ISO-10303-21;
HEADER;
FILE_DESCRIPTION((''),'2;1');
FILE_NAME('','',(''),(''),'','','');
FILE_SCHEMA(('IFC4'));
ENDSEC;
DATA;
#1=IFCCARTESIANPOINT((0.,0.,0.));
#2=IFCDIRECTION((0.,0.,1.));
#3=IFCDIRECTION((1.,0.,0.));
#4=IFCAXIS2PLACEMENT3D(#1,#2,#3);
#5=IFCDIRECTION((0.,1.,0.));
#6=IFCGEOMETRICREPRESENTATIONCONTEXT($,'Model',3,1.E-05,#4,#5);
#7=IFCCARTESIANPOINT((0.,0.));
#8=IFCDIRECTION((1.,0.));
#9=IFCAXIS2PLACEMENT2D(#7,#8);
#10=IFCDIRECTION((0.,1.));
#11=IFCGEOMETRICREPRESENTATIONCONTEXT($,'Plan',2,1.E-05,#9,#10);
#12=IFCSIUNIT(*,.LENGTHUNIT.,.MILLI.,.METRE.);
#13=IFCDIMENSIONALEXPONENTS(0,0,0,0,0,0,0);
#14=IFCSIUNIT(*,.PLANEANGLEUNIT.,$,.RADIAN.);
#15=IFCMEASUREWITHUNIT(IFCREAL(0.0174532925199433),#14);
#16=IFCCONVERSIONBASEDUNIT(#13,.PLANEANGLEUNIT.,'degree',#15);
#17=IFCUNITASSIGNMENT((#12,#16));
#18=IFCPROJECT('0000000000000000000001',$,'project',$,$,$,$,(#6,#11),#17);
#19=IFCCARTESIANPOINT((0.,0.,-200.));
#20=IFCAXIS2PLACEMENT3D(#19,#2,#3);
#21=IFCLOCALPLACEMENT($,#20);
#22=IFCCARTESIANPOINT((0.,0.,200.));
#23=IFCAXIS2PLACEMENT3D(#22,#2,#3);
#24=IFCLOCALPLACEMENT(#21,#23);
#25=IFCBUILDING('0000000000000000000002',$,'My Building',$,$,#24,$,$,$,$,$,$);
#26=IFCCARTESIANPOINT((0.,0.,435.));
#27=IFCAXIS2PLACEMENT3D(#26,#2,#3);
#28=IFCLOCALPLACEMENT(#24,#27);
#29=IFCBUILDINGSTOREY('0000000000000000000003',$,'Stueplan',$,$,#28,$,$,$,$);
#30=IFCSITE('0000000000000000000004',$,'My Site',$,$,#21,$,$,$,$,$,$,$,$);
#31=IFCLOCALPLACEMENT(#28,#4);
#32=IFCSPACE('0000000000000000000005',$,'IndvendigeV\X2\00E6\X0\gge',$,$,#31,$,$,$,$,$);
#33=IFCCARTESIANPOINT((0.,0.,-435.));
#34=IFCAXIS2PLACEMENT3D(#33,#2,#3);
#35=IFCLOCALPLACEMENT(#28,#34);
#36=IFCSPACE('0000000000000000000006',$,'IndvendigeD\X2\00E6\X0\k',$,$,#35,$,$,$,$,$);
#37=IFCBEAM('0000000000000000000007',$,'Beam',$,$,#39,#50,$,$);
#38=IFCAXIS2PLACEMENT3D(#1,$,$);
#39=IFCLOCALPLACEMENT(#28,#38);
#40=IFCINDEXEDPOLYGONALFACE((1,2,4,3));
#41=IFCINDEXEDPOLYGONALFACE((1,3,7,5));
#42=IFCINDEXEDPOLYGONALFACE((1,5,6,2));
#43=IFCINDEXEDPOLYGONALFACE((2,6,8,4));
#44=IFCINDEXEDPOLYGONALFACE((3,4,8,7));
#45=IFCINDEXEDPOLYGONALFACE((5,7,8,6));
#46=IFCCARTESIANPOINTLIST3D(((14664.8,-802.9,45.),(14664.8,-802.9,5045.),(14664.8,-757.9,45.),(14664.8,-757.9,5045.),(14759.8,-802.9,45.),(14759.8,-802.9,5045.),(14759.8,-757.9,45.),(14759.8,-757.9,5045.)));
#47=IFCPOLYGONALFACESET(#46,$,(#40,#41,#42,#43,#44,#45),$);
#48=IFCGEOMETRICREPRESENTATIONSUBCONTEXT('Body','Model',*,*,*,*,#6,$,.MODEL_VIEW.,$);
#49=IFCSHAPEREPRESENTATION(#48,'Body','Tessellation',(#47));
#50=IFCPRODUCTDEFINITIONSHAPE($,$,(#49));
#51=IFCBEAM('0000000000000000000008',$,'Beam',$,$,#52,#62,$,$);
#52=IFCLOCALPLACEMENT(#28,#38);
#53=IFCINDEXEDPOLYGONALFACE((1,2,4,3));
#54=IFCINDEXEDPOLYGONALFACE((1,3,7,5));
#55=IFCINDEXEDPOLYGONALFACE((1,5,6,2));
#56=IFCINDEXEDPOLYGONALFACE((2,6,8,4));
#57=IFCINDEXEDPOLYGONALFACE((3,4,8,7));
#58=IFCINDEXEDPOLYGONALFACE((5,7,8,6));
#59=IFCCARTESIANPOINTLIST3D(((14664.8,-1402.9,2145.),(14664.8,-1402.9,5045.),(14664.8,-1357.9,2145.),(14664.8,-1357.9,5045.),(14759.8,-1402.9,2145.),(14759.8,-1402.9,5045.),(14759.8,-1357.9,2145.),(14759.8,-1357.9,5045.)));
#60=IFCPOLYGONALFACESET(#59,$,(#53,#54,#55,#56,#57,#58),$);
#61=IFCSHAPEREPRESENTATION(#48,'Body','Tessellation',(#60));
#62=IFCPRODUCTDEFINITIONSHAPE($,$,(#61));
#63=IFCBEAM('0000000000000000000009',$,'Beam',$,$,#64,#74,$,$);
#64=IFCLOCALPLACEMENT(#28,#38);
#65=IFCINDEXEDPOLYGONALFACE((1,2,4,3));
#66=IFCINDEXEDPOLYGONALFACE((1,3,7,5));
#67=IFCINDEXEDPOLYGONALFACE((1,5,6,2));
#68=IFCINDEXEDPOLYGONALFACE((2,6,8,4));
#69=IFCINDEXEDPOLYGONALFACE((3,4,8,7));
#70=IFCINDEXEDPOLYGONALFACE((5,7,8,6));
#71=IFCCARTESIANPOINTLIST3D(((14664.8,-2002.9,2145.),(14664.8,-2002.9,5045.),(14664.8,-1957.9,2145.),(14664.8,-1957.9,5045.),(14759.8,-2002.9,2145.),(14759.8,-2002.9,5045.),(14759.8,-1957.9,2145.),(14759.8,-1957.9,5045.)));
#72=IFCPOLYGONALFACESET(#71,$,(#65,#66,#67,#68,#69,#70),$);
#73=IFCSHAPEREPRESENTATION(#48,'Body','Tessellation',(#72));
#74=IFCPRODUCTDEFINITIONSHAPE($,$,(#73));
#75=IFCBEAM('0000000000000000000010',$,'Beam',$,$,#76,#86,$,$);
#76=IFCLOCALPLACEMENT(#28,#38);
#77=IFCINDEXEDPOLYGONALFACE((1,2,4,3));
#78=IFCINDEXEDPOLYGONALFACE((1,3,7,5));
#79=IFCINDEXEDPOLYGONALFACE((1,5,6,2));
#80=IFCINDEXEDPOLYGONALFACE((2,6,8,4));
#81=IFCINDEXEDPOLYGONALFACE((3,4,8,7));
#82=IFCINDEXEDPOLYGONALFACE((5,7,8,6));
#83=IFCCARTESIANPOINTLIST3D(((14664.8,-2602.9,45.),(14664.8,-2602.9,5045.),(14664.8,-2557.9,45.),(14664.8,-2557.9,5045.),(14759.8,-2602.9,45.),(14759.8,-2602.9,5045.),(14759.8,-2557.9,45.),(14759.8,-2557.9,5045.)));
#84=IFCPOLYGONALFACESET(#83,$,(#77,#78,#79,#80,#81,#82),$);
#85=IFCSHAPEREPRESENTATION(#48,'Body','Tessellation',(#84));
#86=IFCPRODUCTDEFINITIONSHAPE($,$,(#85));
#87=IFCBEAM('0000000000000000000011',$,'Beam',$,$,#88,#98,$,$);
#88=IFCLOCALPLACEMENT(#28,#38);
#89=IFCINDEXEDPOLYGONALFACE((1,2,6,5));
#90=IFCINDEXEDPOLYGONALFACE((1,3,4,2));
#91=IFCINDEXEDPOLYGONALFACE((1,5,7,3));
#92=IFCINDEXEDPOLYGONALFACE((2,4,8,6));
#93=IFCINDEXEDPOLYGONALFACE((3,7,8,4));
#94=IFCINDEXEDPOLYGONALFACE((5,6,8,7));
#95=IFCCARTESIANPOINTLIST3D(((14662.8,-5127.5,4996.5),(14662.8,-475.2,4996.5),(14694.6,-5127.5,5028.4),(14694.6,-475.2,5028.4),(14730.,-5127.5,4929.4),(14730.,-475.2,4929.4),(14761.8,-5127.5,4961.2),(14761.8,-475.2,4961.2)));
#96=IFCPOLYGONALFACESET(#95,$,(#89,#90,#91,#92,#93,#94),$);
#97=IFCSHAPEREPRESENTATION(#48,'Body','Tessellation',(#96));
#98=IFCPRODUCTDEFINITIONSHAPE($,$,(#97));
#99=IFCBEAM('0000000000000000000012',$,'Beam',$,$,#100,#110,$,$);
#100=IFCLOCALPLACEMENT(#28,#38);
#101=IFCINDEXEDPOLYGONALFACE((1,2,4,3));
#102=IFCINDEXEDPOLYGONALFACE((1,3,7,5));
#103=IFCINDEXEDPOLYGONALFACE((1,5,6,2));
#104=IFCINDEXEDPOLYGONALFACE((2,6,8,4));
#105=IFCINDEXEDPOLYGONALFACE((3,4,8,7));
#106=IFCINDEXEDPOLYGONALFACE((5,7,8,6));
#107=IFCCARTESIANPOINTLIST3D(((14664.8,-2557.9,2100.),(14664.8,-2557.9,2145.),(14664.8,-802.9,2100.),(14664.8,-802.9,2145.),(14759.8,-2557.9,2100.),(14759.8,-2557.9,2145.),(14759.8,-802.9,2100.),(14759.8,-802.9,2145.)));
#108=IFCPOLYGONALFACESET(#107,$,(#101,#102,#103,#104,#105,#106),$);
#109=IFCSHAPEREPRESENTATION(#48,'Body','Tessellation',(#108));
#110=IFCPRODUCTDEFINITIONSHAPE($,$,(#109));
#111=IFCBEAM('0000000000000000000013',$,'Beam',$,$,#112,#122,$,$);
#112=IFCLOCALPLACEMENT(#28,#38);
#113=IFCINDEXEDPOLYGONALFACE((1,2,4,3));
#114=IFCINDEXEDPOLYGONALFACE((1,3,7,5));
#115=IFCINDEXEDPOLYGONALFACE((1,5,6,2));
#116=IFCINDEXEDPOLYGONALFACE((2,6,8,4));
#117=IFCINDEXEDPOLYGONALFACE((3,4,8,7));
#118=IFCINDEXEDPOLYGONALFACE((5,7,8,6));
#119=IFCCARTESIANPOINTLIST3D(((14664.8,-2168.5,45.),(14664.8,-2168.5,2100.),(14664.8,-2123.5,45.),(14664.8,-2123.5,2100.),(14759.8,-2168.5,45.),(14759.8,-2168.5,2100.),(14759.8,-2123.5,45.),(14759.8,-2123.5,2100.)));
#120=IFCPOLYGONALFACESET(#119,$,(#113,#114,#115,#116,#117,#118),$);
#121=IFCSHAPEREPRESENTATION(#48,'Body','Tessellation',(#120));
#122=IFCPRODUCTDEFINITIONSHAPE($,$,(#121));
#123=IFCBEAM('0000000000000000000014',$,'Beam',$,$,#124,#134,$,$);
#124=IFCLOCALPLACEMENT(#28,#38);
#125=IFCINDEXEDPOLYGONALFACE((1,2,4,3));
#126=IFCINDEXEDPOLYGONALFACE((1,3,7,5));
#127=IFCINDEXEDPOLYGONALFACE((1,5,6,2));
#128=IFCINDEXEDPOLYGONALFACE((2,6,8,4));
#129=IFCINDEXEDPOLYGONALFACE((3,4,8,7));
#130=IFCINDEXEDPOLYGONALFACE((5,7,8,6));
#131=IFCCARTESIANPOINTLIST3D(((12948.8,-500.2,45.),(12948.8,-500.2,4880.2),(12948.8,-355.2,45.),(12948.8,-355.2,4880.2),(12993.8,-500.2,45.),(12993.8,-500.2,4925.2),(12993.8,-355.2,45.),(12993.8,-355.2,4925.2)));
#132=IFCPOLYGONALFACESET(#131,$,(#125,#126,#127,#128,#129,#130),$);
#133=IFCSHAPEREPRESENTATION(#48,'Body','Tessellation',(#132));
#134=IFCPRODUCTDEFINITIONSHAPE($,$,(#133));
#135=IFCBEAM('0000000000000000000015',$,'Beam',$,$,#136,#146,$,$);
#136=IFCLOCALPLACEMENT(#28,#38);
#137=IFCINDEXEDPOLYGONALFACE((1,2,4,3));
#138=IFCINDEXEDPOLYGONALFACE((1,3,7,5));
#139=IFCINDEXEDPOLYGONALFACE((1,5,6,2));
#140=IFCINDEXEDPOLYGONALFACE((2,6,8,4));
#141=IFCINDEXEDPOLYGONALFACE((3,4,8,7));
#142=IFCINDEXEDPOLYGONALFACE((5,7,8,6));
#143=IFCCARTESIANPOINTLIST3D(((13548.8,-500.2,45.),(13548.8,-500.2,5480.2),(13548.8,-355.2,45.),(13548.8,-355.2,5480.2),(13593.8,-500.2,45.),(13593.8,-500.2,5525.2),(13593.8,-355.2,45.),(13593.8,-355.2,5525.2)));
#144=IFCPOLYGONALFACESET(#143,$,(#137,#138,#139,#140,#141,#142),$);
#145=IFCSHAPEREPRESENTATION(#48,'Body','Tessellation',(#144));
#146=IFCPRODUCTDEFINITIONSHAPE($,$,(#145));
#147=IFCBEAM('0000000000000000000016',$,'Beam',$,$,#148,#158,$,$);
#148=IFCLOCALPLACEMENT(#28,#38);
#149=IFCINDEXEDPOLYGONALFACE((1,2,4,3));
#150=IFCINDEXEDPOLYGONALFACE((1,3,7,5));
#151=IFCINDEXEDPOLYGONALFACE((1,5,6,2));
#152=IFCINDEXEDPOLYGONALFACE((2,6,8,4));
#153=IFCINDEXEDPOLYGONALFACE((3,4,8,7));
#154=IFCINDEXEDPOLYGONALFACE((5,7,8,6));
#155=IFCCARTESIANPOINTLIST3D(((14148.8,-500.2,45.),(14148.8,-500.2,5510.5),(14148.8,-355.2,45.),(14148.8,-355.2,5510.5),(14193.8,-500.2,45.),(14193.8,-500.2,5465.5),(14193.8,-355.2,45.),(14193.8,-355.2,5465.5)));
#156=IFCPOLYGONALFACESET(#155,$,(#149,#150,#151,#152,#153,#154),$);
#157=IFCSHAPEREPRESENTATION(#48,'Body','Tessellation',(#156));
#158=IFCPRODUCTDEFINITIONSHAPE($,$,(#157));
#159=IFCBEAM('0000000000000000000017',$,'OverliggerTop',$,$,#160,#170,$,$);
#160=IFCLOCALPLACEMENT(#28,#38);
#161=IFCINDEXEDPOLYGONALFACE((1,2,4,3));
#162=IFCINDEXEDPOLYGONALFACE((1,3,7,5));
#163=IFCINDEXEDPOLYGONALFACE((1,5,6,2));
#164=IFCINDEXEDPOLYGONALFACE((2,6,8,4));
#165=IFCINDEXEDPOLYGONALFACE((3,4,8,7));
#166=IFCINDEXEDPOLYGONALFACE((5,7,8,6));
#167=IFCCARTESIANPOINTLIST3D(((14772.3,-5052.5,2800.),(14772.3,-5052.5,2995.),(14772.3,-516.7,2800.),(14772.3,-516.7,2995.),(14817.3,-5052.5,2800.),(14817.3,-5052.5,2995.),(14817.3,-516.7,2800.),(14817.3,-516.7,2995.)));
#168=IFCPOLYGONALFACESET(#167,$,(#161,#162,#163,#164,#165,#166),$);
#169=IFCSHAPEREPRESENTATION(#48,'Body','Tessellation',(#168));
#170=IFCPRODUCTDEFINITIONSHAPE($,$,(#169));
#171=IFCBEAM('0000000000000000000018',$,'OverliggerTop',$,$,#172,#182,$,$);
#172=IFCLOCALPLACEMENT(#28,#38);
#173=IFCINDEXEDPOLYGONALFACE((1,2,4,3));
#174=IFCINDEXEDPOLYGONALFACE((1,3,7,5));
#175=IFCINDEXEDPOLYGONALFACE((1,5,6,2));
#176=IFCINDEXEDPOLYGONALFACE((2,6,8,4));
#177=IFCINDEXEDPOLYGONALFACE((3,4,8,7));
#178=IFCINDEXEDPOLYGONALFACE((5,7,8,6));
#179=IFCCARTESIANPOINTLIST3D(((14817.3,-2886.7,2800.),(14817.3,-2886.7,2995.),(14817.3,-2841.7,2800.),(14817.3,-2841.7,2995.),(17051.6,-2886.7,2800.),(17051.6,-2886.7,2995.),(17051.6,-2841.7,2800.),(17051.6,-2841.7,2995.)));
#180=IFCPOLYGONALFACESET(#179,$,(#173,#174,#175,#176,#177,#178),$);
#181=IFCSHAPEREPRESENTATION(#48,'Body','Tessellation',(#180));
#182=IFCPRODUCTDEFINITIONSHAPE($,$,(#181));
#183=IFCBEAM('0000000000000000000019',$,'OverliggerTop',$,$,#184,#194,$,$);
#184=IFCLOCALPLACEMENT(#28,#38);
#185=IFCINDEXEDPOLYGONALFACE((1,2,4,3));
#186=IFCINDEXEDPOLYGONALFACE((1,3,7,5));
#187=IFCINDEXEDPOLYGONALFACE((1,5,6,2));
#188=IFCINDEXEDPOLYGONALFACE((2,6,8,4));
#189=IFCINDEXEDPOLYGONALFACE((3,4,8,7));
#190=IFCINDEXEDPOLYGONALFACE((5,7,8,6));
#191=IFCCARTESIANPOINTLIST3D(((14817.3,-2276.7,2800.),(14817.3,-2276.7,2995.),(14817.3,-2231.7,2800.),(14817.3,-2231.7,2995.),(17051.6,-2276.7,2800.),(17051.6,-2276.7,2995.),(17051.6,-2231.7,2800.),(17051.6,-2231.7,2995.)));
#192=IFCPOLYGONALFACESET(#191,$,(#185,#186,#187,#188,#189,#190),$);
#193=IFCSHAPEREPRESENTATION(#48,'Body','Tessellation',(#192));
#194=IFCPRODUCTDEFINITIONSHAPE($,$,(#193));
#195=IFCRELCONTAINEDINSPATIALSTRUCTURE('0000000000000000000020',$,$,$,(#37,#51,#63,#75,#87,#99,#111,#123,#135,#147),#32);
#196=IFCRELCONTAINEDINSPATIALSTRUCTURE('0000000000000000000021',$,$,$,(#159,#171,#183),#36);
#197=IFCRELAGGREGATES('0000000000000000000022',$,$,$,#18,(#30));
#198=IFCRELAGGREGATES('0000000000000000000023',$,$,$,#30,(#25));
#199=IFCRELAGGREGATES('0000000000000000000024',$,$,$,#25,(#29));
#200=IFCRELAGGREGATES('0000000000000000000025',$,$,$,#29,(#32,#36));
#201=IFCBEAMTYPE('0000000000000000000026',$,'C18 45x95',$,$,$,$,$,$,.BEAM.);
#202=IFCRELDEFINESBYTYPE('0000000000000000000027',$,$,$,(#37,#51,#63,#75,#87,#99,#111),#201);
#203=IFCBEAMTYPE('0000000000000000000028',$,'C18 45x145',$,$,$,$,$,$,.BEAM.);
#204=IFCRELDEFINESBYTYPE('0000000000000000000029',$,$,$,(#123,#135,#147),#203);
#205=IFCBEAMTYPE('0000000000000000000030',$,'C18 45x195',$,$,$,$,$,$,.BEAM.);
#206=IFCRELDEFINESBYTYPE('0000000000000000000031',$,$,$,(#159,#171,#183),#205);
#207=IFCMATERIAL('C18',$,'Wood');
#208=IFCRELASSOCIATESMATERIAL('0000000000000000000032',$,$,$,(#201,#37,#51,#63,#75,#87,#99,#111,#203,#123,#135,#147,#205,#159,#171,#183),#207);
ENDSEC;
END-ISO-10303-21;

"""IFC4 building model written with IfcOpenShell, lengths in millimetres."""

from ifc_helpers import new_model, entity, si_unit, converted_unit, direction, frame, origin_with_axes, origin_2d_with_axis, place, context, subcontext, project, spatial, rectangle, extrude, clip, halfspace, material, material_profile, profile_set, profile_usage, type_object, element, save


model = new_model("IFC4")

# Units and contexts
model_context = context("Model", 3, precision=1e-05, world=origin_with_axes(), true_north=direction((0.0, 1.0, 0.0)))
plan_context = context("Plan", 2, precision=1e-05, world=origin_2d_with_axis(), true_north=direction((0.0, 1.0)))
body_context_1 = subcontext(model_context, "Body", "Model", "MODEL_VIEW")
ifc_project = project(units=[si_unit("LENGTHUNIT", "METRE", prefix="MILLI"), converted_unit("PLANEANGLEUNIT", "degree", entity("IfcReal", 0.0174532925199433), si_unit("PLANEANGLEUNIT", "RADIAN"), dimensions=[0, 0, 0, 0, 0, 0, 0])], contexts=[model_context, plan_context])

# Site, building, storey
site_placement = place(None, frame((0.0, 0.0, -200.0), z_axis=(0.0, 0.0, 1.0), x_axis=(1.0, 0.0, 0.0)))
site = spatial("IfcSite", under=ifc_project, at=site_placement, Name="My Site")
building_placement = place(site_placement, frame((0.0, 0.0, 200.0), z_axis=(0.0, 0.0, 1.0), x_axis=(1.0, 0.0, 0.0)))
building = spatial("IfcBuilding", under=site, at=building_placement, Name="My Building")
storey_placement = place(building_placement, frame((0.0, 0.0, 435.0), z_axis=(0.0, 0.0, 1.0), x_axis=(1.0, 0.0, 0.0)))
storey = spatial("IfcBuildingStorey", under=building, at=storey_placement, Name="Stueplan")

# Shared definitions
ifc_material = material(Name="C18", Category="Wood")

# Shared definitions
space_1_placement = place(storey_placement, frame((0.0, 0.0, 0.0), z_axis=(0.0, 0.0, 1.0), x_axis=(1.0, 0.0, 0.0)))
space_1 = spatial("IfcSpace", under=storey, at=space_1_placement, Name="IndvendigeVægge")

# Beams
ifc_material_profile_1 = material_profile(ifc_material, rectangle(XDim=45.0, YDim=95.0))
ifc_profile_set_1 = profile_set([ifc_material_profile_1], Name="woodStructural")
beam_type_1 = type_object("IfcBeamType", Name="C18 45x95", PredefinedType="BEAM", material=ifc_profile_set_1)
ifc_profile_usage_1 = profile_usage(ifc_profile_set_1)
beam_1_placement = place(space_1_placement, frame((14712.3, -780.4, 45.0), z_axis=(0.0, 0.0, 1.0), x_axis=(0.0, 1.0, 0.0)))
element("IfcBeam", 1, at=beam_1_placement, inside=space_1, type_object=beam_type_1, material=ifc_profile_usage_1, Name="Beam", context=body_context_1, shape_type="SweptSolid", body=[
    extrude(rectangle(XDim=45.0, YDim=95.0), origin_with_axes(), (0.0, 0.0, 1.0), 5000.0),
])
ifc_profile_usage_2 = profile_usage(ifc_profile_set_1)
beam_2_placement = place(space_1_placement, frame((14712.3, -1380.4, 2145.0), z_axis=(0.0, 0.0, 1.0), x_axis=(0.0, 1.0, 0.0)))
element("IfcBeam", 2, at=beam_2_placement, inside=space_1, type_object=beam_type_1, material=ifc_profile_usage_2, Name="Beam", context=body_context_1, shape_type="SweptSolid", body=[
    extrude(rectangle(XDim=45.0, YDim=95.0), origin_with_axes(), (0.0, 0.0, 1.0), 2900.0),
])
ifc_profile_usage_3 = profile_usage(ifc_profile_set_1)
beam_3_placement = place(space_1_placement, frame((14712.3, -1980.4, 2145.0), z_axis=(0.0, 0.0, 1.0), x_axis=(0.0, 1.0, 0.0)))
element("IfcBeam", 3, at=beam_3_placement, inside=space_1, type_object=beam_type_1, material=ifc_profile_usage_3, Name="Beam", context=body_context_1, shape_type="SweptSolid", body=[
    extrude(rectangle(XDim=45.0, YDim=95.0), origin_with_axes(), (0.0, 0.0, 1.0), 2900.0),
])
ifc_profile_usage_4 = profile_usage(ifc_profile_set_1)
beam_4_placement = place(space_1_placement, frame((14712.3, -2580.4, 45.0), z_axis=(0.0, 0.0, 1.0), x_axis=(0.0, 1.0, 0.0)))
element("IfcBeam", 4, at=beam_4_placement, inside=space_1, type_object=beam_type_1, material=ifc_profile_usage_4, Name="Beam", context=body_context_1, shape_type="SweptSolid", body=[
    extrude(rectangle(XDim=45.0, YDim=95.0), origin_with_axes(), (0.0, 0.0, 1.0), 5000.0),
])
ifc_profile_usage_5 = profile_usage(ifc_profile_set_1, cardinal=5)
beam_5_placement = place(space_1_placement, frame((14712.3, -5127.5, 4978.9), z_axis=(0.0, 1.0, 0.0), x_axis=(0.707107, 0.0, 0.707107)))
element("IfcBeam", 5, at=beam_5_placement, inside=space_1, type_object=beam_type_1, material=ifc_profile_usage_5, Name="Beam", context=body_context_1, shape_type="SweptSolid", body=[
    extrude(rectangle(XDim=45.0, YDim=95.0), origin_with_axes(), (0.0, 0.0, 1.0), 4652.3),
])
ifc_profile_usage_6 = profile_usage(ifc_profile_set_1, cardinal=5)
beam_6_placement = place(space_1_placement, frame((14712.3, -2557.9, 2122.5), z_axis=(0.0, 1.0, 0.0), x_axis=(0.0, 0.0, 1.0)))
element("IfcBeam", 6, at=beam_6_placement, inside=space_1, type_object=beam_type_1, material=ifc_profile_usage_6, Name="Beam", context=body_context_1, shape_type="SweptSolid", body=[
    extrude(rectangle(XDim=45.0, YDim=95.0), origin_with_axes(), (0.0, 0.0, 1.0), 1755.0),
])
ifc_profile_usage_7 = profile_usage(ifc_profile_set_1)
beam_7_placement = place(space_1_placement, frame((14712.3, -2146.0, 45.0), z_axis=(0.0, 0.0, 1.0), x_axis=(0.0, 1.0, 0.0)))
element("IfcBeam", 7, at=beam_7_placement, inside=space_1, type_object=beam_type_1, material=ifc_profile_usage_7, Name="Beam", context=body_context_1, shape_type="SweptSolid", body=[
    extrude(rectangle(XDim=45.0, YDim=95.0), origin_with_axes(), (0.0, 0.0, 1.0), 2055.0),
])
ifc_material_profile_2 = material_profile(ifc_material, rectangle(XDim=45.0, YDim=145.0))
ifc_profile_set_2 = profile_set([ifc_material_profile_2], Name="woodStructural")
beam_type_2 = type_object("IfcBeamType", Name="C18 45x145", PredefinedType="BEAM", material=ifc_profile_set_2)
ifc_profile_usage_8 = profile_usage(ifc_profile_set_2)
beam_8_placement = place(space_1_placement, frame((12971.3, -427.7, 45.0), z_axis=(0.0, 0.0, 1.0), x_axis=(-1.0, 0.0, 0.0)))
element("IfcBeam", 8, at=beam_8_placement, inside=space_1, type_object=beam_type_2, material=ifc_profile_usage_8, Name="Beam", context=body_context_1, shape_type="Clipping", body=[
    clip(extrude(rectangle(XDim=45.0, YDim=145.0), origin_with_axes(), (0.0, 0.0, 1.0), 5002.7), halfspace(frame((-946.1, 0.0, 5803.8), z_axis=(0.707107, 0.0, 0.707107), x_axis=(0.0, -1.0, 0.0)), False)),
])
ifc_profile_usage_9 = profile_usage(ifc_profile_set_2)
beam_9_placement = place(space_1_placement, frame((13571.3, -427.7, 45.0), z_axis=(0.0, 0.0, 1.0), x_axis=(-1.0, 0.0, 0.0)))
element("IfcBeam", 9, at=beam_9_placement, inside=space_1, type_object=beam_type_2, material=ifc_profile_usage_9, Name="Beam", context=body_context_1, shape_type="Clipping", body=[
    clip(extrude(rectangle(XDim=45.0, YDim=145.0), origin_with_axes(), (0.0, 0.0, 1.0), 5602.7), halfspace(frame((-346.1, 0.0, 5803.8), z_axis=(0.707107, 0.0, 0.707107), x_axis=(0.0, -1.0, 0.0)), False)),
])
ifc_profile_usage_10 = profile_usage(ifc_profile_set_2)
beam_10_placement = place(space_1_placement, frame((14171.3, -427.7, 45.0), z_axis=(0.0, 0.0, 1.0), x_axis=(-1.0, 0.0, 0.0)))
element("IfcBeam", 10, at=beam_10_placement, inside=space_1, type_object=beam_type_2, material=ifc_profile_usage_10, Name="Beam", context=body_context_1, shape_type="Clipping", body=[
    clip(extrude(rectangle(XDim=45.0, YDim=145.0), origin_with_axes(), (0.0, 0.0, 1.0), 5588.0), halfspace(frame((355.8, 0.0, 5798.8), z_axis=(-0.707107, 0.0, 0.707107), x_axis=(0.0, 1.0, 0.0)), False)),
])

# Shared definitions
space_2_placement = place(storey_placement, frame((0.0, 0.0, -435.0), z_axis=(0.0, 0.0, 1.0), x_axis=(1.0, 0.0, 0.0)))
space_2 = spatial("IfcSpace", under=storey, at=space_2_placement, Name="IndvendigeDæk")

# Beams
ifc_material_profile_3 = material_profile(ifc_material, rectangle(XDim=45.0, YDim=195.0))
ifc_profile_set_3 = profile_set([ifc_material_profile_3], Name="woodStructural")
ifc_profile_usage_11 = profile_usage(ifc_profile_set_3)
beam_type_3 = type_object("IfcBeamType", Name="C18 45x195", PredefinedType="BEAM", material=ifc_profile_set_3)
beam_11_placement = place(space_2_placement, frame((14794.8, -516.7, 3332.5), z_axis=(0.000001, -1.0, 0.0), x_axis=(-1.0, -0.000001, 0.0)))
element("IfcBeam", 11, at=beam_11_placement, inside=space_2, type_object=beam_type_3, material=ifc_profile_usage_11, Name="OverliggerTop", context=body_context_1, shape_type="SweptSolid", body=[
    extrude(rectangle(XDim=45.0, YDim=195.0), origin_with_axes(), (0.0, 0.0, 1.0), 4535.8),
])
ifc_profile_usage_12 = profile_usage(ifc_profile_set_3)
beam_12_placement = place(space_2_placement, frame((14817.3, -2864.2, 3332.5), z_axis=(1.0, 0.000001, 0.0), x_axis=(0.000001, -1.0, 0.0)))
element("IfcBeam", 12, at=beam_12_placement, inside=space_2, type_object=beam_type_3, material=ifc_profile_usage_12, Name="OverliggerTop", context=body_context_1, shape_type="SweptSolid", body=[
    extrude(rectangle(XDim=45.0, YDim=195.0), origin_with_axes(), (0.0, 0.0, 1.0), 2234.3),
])
ifc_profile_usage_13 = profile_usage(ifc_profile_set_3)
beam_13_placement = place(space_2_placement, frame((14817.3, -2254.2, 3332.5), z_axis=(1.0, 0.000001, 0.0), x_axis=(0.000001, -1.0, 0.0)))
element("IfcBeam", 13, at=beam_13_placement, inside=space_2, type_object=beam_type_3, material=ifc_profile_usage_13, Name="OverliggerTop", context=body_context_1, shape_type="SweptSolid", body=[
    extrude(rectangle(XDim=45.0, YDim=195.0), origin_with_axes(), (0.0, 0.0, 1.0), 2234.3),
])

save(model, "model.ifc")
